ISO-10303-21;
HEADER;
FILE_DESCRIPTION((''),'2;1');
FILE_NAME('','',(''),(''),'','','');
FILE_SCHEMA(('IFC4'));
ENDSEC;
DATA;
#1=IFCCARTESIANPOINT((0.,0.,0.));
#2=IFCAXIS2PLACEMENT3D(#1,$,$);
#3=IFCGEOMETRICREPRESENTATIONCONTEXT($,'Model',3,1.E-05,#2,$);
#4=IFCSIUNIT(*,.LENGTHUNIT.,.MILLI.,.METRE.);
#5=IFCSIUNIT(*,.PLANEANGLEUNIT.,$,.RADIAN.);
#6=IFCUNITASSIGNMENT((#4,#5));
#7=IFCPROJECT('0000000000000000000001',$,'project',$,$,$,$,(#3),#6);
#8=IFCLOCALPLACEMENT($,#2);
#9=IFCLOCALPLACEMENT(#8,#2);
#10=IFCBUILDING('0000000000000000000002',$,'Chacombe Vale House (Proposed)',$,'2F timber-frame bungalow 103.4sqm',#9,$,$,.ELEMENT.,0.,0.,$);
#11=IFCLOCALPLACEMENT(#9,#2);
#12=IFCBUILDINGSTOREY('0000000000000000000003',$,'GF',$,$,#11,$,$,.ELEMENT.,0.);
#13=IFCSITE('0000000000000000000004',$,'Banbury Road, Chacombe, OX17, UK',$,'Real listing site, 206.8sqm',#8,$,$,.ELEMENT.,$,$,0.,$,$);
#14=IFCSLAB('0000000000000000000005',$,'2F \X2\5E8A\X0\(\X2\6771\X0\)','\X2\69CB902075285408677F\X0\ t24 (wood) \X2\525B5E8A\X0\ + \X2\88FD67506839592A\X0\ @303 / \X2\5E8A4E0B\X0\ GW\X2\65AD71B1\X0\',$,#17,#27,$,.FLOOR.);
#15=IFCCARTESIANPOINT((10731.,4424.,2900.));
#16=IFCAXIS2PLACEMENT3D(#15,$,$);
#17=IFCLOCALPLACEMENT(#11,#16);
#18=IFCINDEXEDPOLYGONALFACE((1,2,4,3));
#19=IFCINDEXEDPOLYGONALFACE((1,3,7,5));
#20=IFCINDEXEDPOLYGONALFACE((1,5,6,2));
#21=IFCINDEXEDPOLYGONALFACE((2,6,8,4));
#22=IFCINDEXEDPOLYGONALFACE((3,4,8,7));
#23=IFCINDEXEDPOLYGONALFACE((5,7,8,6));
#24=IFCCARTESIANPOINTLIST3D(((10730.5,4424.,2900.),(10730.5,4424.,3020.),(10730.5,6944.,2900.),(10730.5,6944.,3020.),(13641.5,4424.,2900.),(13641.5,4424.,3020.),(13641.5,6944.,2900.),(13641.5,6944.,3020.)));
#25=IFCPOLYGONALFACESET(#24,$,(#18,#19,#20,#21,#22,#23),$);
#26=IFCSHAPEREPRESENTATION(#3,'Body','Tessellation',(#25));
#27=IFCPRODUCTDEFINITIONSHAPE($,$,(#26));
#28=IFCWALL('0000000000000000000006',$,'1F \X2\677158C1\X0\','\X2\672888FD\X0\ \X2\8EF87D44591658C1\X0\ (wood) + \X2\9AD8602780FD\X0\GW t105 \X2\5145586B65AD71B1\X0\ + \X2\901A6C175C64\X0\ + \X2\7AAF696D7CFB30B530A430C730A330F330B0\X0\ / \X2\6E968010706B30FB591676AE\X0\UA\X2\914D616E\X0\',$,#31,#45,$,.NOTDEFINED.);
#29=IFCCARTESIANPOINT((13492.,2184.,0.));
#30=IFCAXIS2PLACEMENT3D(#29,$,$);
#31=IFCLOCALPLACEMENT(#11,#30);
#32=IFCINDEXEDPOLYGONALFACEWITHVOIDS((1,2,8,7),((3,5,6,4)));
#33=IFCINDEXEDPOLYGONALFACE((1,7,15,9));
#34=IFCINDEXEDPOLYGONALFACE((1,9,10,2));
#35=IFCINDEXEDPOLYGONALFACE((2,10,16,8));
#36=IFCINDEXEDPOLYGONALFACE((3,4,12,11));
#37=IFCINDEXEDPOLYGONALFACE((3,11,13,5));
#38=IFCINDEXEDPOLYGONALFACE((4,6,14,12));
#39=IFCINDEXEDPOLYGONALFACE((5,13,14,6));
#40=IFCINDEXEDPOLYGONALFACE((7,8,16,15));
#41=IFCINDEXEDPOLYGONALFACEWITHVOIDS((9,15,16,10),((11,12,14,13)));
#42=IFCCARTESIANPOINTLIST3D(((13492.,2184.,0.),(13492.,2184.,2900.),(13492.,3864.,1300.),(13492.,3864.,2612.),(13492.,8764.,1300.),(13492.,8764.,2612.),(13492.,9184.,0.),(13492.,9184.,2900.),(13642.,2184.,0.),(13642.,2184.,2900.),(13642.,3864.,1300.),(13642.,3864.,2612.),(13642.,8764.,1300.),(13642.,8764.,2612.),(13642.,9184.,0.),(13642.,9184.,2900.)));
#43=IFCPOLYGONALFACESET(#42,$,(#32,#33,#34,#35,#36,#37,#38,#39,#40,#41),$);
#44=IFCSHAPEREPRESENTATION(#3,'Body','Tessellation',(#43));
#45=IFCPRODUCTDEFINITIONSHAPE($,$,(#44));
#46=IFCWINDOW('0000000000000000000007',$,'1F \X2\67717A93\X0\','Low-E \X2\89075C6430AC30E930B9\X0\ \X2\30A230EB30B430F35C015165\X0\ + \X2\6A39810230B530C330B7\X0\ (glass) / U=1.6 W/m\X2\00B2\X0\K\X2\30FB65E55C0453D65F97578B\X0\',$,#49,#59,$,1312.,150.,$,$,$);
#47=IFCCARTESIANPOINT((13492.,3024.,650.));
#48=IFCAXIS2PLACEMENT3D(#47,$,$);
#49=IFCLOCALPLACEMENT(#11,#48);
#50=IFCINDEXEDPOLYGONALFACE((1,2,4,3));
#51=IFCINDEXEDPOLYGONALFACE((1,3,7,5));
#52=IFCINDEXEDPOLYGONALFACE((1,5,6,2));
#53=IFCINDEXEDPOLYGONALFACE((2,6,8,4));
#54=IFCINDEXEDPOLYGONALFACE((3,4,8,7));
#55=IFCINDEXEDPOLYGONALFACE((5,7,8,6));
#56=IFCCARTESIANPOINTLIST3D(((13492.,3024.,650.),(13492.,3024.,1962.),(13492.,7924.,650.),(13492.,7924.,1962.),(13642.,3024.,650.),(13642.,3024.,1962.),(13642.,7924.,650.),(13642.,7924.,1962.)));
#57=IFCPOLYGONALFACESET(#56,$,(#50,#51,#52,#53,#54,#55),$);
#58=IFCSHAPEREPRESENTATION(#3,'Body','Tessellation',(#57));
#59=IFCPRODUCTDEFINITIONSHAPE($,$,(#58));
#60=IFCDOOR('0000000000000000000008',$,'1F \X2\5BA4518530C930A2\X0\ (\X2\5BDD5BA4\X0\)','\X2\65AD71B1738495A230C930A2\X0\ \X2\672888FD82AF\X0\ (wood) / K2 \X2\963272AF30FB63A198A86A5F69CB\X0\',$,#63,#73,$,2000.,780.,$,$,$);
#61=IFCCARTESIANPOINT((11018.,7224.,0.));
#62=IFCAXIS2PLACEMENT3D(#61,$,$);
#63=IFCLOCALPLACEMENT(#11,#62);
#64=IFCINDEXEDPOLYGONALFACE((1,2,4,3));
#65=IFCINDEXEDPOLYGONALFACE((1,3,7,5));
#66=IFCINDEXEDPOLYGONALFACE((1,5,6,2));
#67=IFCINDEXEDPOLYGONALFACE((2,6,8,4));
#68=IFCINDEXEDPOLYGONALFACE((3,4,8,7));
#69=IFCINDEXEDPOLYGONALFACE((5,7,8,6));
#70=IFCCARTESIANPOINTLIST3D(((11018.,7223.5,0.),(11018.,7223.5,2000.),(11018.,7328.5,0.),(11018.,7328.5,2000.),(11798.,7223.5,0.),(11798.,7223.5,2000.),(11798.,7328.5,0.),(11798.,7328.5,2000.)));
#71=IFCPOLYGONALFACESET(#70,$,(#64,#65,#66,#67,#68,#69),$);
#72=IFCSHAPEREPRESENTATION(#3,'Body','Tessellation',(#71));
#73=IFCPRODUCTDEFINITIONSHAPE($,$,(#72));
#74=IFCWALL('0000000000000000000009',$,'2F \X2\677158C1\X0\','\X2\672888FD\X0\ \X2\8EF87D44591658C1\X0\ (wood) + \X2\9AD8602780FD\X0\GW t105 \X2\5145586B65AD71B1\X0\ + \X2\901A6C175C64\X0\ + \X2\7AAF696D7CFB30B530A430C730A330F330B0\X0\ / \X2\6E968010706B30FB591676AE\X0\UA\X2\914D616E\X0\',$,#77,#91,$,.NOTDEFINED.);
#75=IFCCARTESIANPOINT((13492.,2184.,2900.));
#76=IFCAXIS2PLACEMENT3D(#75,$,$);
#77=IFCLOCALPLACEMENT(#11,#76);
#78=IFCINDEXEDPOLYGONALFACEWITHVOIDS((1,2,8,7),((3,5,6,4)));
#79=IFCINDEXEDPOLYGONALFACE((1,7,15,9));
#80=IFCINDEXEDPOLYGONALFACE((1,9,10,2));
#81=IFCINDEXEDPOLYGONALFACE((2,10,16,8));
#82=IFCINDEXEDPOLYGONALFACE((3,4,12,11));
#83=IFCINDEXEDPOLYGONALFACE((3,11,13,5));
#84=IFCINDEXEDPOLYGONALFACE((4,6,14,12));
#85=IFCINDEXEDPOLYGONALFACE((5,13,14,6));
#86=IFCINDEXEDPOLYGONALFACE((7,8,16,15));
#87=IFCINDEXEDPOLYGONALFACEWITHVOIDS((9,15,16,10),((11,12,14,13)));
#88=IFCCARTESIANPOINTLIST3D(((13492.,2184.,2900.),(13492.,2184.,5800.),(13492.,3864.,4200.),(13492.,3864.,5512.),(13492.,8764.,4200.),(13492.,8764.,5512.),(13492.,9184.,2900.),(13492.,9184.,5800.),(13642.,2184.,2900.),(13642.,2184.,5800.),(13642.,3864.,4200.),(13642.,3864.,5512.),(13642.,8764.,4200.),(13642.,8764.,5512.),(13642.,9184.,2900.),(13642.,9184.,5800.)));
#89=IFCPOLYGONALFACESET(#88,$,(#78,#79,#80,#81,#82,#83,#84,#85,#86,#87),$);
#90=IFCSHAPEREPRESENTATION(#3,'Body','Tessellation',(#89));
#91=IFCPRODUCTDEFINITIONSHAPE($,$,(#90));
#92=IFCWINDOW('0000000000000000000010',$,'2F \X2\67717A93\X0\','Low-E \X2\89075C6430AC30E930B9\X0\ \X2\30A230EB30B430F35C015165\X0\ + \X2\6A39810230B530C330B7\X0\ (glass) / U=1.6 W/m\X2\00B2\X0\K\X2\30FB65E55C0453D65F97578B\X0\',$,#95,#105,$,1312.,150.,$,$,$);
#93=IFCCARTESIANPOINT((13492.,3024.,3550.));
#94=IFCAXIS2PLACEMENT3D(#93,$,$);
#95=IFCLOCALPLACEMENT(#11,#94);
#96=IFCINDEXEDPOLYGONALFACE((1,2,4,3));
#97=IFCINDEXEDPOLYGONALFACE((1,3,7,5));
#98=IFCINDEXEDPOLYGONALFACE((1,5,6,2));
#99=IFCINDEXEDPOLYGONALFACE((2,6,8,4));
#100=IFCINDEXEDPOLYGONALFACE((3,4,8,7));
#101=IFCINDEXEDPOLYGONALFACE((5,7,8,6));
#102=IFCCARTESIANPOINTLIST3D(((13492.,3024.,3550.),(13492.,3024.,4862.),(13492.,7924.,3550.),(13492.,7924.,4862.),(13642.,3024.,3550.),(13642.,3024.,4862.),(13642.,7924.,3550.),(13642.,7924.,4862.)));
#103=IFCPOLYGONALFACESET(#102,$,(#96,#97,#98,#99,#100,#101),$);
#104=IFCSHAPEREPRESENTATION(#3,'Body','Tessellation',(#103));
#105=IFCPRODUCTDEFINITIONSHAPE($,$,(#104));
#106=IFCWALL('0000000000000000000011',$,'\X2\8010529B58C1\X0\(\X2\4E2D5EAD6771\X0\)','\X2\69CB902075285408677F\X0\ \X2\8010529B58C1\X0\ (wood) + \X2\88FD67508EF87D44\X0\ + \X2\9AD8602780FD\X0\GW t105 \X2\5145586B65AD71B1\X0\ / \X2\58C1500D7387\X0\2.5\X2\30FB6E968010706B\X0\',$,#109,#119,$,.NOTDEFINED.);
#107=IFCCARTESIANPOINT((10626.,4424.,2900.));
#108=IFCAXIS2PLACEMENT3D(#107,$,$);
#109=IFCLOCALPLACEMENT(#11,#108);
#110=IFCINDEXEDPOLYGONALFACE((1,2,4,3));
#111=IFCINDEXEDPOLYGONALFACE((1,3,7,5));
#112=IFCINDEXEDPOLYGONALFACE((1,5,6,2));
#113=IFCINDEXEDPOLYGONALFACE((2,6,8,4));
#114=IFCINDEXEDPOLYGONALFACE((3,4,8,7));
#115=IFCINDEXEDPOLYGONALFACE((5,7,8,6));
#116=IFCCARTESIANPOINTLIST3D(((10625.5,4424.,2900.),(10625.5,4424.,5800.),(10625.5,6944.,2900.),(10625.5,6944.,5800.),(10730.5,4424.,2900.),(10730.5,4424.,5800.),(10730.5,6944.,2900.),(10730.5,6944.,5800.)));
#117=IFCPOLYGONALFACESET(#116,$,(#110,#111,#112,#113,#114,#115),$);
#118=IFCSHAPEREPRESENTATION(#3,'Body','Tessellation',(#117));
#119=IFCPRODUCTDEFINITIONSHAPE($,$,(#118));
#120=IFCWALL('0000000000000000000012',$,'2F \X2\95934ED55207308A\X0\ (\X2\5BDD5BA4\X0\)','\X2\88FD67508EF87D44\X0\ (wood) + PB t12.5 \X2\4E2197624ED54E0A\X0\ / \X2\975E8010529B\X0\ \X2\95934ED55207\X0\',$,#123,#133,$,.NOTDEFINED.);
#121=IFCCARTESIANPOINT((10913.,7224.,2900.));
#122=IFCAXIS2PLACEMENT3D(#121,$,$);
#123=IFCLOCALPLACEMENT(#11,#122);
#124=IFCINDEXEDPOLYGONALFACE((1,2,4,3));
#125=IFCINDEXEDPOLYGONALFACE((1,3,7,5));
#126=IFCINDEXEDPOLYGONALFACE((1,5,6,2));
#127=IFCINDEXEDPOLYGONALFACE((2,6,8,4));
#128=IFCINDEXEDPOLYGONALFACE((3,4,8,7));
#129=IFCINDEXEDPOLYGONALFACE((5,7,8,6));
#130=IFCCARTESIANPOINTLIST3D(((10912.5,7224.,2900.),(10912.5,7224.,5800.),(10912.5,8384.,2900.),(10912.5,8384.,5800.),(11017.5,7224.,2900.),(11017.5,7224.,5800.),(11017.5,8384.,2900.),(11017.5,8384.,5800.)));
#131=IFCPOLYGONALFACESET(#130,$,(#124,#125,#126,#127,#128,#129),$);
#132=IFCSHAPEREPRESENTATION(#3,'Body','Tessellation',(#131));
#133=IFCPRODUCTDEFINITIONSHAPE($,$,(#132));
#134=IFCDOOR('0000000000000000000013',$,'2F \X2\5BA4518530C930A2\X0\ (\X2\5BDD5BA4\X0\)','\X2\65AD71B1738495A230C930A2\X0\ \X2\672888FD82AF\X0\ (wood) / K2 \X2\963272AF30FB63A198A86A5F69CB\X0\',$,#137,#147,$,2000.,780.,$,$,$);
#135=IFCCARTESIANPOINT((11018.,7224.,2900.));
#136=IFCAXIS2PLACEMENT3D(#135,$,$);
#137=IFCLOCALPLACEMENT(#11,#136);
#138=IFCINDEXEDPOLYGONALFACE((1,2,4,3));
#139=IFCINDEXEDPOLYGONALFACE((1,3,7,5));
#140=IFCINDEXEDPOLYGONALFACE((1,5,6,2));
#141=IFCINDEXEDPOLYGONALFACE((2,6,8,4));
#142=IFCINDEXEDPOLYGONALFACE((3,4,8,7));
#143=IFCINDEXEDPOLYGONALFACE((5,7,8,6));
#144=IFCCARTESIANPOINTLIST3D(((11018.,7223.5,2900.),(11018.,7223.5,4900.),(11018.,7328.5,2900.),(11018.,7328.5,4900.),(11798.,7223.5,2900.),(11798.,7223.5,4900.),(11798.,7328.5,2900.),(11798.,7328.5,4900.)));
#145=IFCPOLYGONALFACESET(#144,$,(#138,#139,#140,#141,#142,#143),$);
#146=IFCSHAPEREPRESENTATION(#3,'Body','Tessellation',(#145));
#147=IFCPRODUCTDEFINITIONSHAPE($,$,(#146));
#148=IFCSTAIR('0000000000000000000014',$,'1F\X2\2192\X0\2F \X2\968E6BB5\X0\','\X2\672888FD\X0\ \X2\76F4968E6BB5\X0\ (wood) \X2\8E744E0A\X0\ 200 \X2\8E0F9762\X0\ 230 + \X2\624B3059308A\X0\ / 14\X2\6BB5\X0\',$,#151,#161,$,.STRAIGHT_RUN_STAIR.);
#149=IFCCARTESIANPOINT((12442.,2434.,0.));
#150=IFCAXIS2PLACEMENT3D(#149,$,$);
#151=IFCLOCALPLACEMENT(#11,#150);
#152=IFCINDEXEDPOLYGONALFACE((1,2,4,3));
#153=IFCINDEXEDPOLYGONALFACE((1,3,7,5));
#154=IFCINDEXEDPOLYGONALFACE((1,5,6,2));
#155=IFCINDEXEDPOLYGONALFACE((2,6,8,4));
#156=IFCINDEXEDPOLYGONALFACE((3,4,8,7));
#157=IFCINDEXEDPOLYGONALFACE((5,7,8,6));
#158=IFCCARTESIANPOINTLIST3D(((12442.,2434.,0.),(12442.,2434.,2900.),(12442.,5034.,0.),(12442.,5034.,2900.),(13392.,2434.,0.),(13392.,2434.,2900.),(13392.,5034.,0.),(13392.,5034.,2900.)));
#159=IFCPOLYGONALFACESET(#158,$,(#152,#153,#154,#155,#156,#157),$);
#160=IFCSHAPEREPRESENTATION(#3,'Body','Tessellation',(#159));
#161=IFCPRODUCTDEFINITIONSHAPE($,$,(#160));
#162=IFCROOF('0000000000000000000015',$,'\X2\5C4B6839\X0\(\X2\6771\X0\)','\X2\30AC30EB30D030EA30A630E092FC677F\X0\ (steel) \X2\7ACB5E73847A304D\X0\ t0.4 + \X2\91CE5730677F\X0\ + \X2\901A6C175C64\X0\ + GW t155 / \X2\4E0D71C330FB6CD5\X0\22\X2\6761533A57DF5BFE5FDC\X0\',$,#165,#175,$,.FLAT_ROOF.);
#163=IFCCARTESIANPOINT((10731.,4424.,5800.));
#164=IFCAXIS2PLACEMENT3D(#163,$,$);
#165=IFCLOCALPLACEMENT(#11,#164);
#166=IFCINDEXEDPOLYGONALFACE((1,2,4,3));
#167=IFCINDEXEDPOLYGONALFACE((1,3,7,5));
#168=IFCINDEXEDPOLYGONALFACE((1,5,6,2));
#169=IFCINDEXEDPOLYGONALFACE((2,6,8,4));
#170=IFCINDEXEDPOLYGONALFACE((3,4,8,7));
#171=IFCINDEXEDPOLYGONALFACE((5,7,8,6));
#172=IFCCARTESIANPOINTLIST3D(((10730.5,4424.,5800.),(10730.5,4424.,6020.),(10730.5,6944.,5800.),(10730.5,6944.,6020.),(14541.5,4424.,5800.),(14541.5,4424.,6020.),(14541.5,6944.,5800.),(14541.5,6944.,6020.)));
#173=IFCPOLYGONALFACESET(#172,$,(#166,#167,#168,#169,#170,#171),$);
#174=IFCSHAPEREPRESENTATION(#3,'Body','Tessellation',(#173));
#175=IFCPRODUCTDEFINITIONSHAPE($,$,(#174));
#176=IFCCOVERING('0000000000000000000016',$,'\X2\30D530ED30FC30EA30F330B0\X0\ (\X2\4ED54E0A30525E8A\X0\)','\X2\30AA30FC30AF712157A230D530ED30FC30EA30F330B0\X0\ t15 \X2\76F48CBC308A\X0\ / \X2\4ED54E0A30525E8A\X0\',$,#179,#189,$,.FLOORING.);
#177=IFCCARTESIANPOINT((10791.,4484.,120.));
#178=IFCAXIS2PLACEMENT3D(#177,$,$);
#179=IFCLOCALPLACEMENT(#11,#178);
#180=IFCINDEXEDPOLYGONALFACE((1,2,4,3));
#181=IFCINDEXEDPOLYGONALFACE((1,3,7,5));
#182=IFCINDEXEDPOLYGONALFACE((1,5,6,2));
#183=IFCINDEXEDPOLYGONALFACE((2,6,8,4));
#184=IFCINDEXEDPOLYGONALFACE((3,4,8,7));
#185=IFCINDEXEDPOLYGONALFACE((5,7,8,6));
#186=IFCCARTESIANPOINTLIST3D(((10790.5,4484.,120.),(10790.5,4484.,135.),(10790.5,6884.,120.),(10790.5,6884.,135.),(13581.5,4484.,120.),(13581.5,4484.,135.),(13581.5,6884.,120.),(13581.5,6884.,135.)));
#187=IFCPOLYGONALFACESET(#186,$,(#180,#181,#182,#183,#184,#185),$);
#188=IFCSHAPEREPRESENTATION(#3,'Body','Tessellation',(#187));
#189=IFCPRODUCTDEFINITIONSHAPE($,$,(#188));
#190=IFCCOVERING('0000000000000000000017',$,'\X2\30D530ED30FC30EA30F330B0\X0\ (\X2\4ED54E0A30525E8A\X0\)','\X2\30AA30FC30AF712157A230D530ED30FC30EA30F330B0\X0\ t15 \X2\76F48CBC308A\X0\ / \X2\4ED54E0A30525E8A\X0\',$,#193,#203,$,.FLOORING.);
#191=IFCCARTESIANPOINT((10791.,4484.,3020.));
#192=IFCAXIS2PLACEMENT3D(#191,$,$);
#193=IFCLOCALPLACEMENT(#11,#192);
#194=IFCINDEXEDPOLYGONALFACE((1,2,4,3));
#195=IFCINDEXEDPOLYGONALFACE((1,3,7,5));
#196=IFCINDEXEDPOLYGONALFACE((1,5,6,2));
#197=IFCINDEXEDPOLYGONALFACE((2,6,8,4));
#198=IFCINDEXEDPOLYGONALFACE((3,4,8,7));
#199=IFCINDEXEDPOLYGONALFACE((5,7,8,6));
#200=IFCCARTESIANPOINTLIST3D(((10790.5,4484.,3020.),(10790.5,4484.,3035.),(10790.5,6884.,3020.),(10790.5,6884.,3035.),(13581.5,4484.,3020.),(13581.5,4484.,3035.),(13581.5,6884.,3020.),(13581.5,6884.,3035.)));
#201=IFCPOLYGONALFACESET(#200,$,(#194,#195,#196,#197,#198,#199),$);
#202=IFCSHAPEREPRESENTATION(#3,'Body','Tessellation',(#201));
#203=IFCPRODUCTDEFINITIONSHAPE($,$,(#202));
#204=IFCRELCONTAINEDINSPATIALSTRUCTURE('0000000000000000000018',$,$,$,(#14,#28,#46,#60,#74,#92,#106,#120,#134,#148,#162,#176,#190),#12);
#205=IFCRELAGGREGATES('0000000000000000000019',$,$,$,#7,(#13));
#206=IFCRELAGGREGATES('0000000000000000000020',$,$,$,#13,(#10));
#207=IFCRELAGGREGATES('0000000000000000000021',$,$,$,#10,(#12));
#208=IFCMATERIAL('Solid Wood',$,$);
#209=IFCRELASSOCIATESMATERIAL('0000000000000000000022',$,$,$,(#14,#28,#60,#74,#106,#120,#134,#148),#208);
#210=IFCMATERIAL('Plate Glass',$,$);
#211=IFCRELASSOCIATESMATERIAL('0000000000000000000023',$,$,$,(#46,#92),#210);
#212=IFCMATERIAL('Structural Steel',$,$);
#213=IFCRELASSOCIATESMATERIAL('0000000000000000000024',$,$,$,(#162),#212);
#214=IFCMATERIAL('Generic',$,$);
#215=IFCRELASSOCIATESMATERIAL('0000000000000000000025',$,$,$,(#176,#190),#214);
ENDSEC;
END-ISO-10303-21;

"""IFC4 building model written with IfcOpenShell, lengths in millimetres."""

from ifc_helpers import new_model, si_unit, frame, frame_2d, origin, place, context, project, spatial, rectangle, extrude, material, element, fill, save


model = new_model("IFC4")

# Units and contexts
model_context = context("Model", 3, precision=1e-05, world=origin())
ifc_project = project(units=[si_unit("LENGTHUNIT", "METRE", prefix="MILLI"), si_unit("PLANEANGLEUNIT", "RADIAN")], contexts=[model_context])

# Site, building, storey
site_placement = place(None, origin())
site = spatial("IfcSite", under=ifc_project, at=site_placement, Name="Banbury Road, Chacombe, OX17, UK", ObjectType="Real listing site, 206.8sqm", CompositionType="ELEMENT", RefElevation=0.0)
building_placement = place(site_placement, origin())
building = spatial("IfcBuilding", under=site, at=building_placement, Name="Chacombe Vale House (Proposed)", ObjectType="2F timber-frame bungalow 103.4sqm", CompositionType="ELEMENT", ElevationOfRefHeight=0.0, ElevationOfTerrain=0.0)
storey_placement = place(building_placement, origin())
storey = spatial("IfcBuildingStorey", under=building, at=storey_placement, Name="GF", CompositionType="ELEMENT", Elevation=0.0)

# Slab
ifc_material_1 = material(Name="Solid Wood")
slab_1_placement = place(storey_placement, frame((10731.0, 4424.0, 2900.0)))
element("IfcSlab", 1, at=slab_1_placement, inside=storey, material=ifc_material_1, Name="2F 床(東)", Description="構造用合板 t24 (wood) 剛床 + 製材根太 @303 / 床下 GW断熱", PredefinedType="FLOOR", context=model_context, shape_type="SweptSolid", body=[
    extrude(rectangle(XDim=2911.0, YDim=2520.0, at=frame_2d((1455.0, 1260.0))), frame((10731.0, 4424.0, 2900.0)), (0.0, 0.0, 1.0), 120.0),
])

# Wall, opening, window
wall_1_placement = place(storey_placement, frame((13492.0, 2184.0, 0.0)))
wall_1 = element("IfcWall", 2, at=wall_1_placement, inside=storey, material=ifc_material_1, Name="1F 東壁", Description="木製 軸組外壁 (wood) + 高性能GW t105 充填断熱 + 通気層 + 窯業系サイディング / 準耐火・外皮UA配慮", PredefinedType="NOTDEFINED", context=model_context, shape_type="SweptSolid", body=[
    extrude(rectangle(XDim=150.0, YDim=7000.0, at=frame_2d((75.0, 3500.0))), frame((13492.0, 2184.0, 0.0)), (0.0, 0.0, 1.0), 2900.0),
])
opening_1_placement = place(storey_placement, frame((13492.0, 3024.0, 650.0)))
opening_1 = element("IfcOpeningElement", 3, at=opening_1_placement, cuts=wall_1, PredefinedType="NOTDEFINED", context=model_context, shape_type="SweptSolid", body=[
    extrude(rectangle(XDim=150.0, YDim=4900.0, at=frame_2d((75.0, 2450.0))), frame((13492.0, 3024.0, 650.0)), (0.0, 0.0, 1.0), 1312.0),
])
ifc_material_2 = material(Name="Plate Glass")
window_1_placement = place(storey_placement, frame((13492.0, 3024.0, 650.0)))
window_1 = element("IfcWindow", 4, at=window_1_placement, inside=storey, material=ifc_material_2, Name="1F 東窓", Description="Low-E 複層ガラス アルゴン封入 + 樹脂サッシ (glass) / U=1.6 W/m²K・日射取得型", OverallHeight=1312.0, OverallWidth=150.0, context=model_context, shape_type="SweptSolid", body=[
    extrude(rectangle(XDim=150.0, YDim=4900.0, at=frame_2d((75.0, 2450.0))), frame((13492.0, 3024.0, 650.0)), (0.0, 0.0, 1.0), 1312.0),
])
fill(opening_1, window_1)

# Door
door_1_placement = place(storey_placement, frame((11018.0, 7224.0, 0.0)))
element("IfcDoor", 5, at=door_1_placement, inside=storey, material=ifc_material_1, Name="1F 室内ドア (寝室)", Description="断熱玄関ドア 木製芯 (wood) / K2 防犯・採風機構", OverallHeight=2000.0, OverallWidth=780.0, context=model_context, shape_type="SweptSolid", body=[
    extrude(rectangle(XDim=780.0, YDim=105.0, at=frame_2d((390.0, 52.0))), frame((11018.0, 7224.0, 0.0)), (0.0, 0.0, 1.0), 2000.0),
])

# Wall, opening, window
wall_2_placement = place(storey_placement, frame((13492.0, 2184.0, 2900.0)))
wall_2 = element("IfcWall", 6, at=wall_2_placement, inside=storey, material=ifc_material_1, Name="2F 東壁", Description="木製 軸組外壁 (wood) + 高性能GW t105 充填断熱 + 通気層 + 窯業系サイディング / 準耐火・外皮UA配慮", PredefinedType="NOTDEFINED", context=model_context, shape_type="SweptSolid", body=[
    extrude(rectangle(XDim=150.0, YDim=7000.0, at=frame_2d((75.0, 3500.0))), frame((13492.0, 2184.0, 2900.0)), (0.0, 0.0, 1.0), 2900.0),
])
opening_2_placement = place(storey_placement, frame((13492.0, 3024.0, 3550.0)))
opening_2 = element("IfcOpeningElement", 7, at=opening_2_placement, cuts=wall_2, PredefinedType="NOTDEFINED", context=model_context, shape_type="SweptSolid", body=[
    extrude(rectangle(XDim=150.0, YDim=4900.0, at=frame_2d((75.0, 2450.0))), frame((13492.0, 3024.0, 3550.0)), (0.0, 0.0, 1.0), 1312.0),
])
window_2_placement = place(storey_placement, frame((13492.0, 3024.0, 3550.0)))
window_2 = element("IfcWindow", 8, at=window_2_placement, inside=storey, material=ifc_material_2, Name="2F 東窓", Description="Low-E 複層ガラス アルゴン封入 + 樹脂サッシ (glass) / U=1.6 W/m²K・日射取得型", OverallHeight=1312.0, OverallWidth=150.0, context=model_context, shape_type="SweptSolid", body=[
    extrude(rectangle(XDim=150.0, YDim=4900.0, at=frame_2d((75.0, 2450.0))), frame((13492.0, 3024.0, 3550.0)), (0.0, 0.0, 1.0), 1312.0),
])
fill(opening_2, window_2)

# Walls
wall_3_placement = place(storey_placement, frame((10626.0, 4424.0, 2900.0)))
element("IfcWall", 9, at=wall_3_placement, inside=storey, material=ifc_material_1, Name="耐力壁(中庭東)", Description="構造用合板 耐力壁 (wood) + 製材軸組 + 高性能GW t105 充填断熱 / 壁倍率2.5・準耐火", PredefinedType="NOTDEFINED", context=model_context, shape_type="SweptSolid", body=[
    extrude(rectangle(XDim=105.0, YDim=2520.0, at=frame_2d((52.0, 1260.0))), frame((10626.0, 4424.0, 2900.0)), (0.0, 0.0, 1.0), 2900.0),
])
wall_4_placement = place(storey_placement, frame((10913.0, 7224.0, 2900.0)))
element("IfcWall", 10, at=wall_4_placement, inside=storey, material=ifc_material_1, Name="2F 間仕切り (寝室)", Description="製材軸組 (wood) + PB t12.5 両面仕上 / 非耐力 間仕切", PredefinedType="NOTDEFINED", context=model_context, shape_type="SweptSolid", body=[
    extrude(rectangle(XDim=105.0, YDim=1160.0, at=frame_2d((52.0, 580.0))), frame((10913.0, 7224.0, 2900.0)), (0.0, 0.0, 1.0), 2900.0),
])

# Door
door_2_placement = place(storey_placement, frame((11018.0, 7224.0, 2900.0)))
element("IfcDoor", 11, at=door_2_placement, inside=storey, material=ifc_material_1, Name="2F 室内ドア (寝室)", Description="断熱玄関ドア 木製芯 (wood) / K2 防犯・採風機構", OverallHeight=2000.0, OverallWidth=780.0, context=model_context, shape_type="SweptSolid", body=[
    extrude(rectangle(XDim=780.0, YDim=105.0, at=frame_2d((390.0, 52.0))), frame((11018.0, 7224.0, 2900.0)), (0.0, 0.0, 1.0), 2000.0),
])

# Stair
stair_placement = place(storey_placement, frame((12442.0, 2434.0, 0.0)))
element("IfcStair", 12, at=stair_placement, inside=storey, material=ifc_material_1, Name="1F→2F 階段", Description="木製 直階段 (wood) 蹴上 200 踏面 230 + 手すり / 14段", PredefinedType="STRAIGHT_RUN_STAIR", context=model_context, shape_type="SweptSolid", body=[
    extrude(rectangle(XDim=950.0, YDim=2600.0, at=frame_2d((475.0, 1300.0))), frame((12442.0, 2434.0, 0.0)), (0.0, 0.0, 1.0), 2900.0),
])

# Roof
ifc_material_3 = material(Name="Structural Steel")
for number, where, name in (
    (13, (10731.0, 4424.0, 5800.0), "屋根(東)"),
):
    element("IfcRoof", number, at=place(storey_placement, frame(where)), inside=storey, material=ifc_material_3, Name=name, Description="ガルバリウム鋼板 (steel) 立平葺き t0.4 + 野地板 + 通気層 + GW t155 / 不燃・法22条区域対応", PredefinedType="FLAT_ROOF", context=model_context, shape_type="SweptSolid", body=[
        extrude(rectangle(XDim=3811.0, YDim=2520.0, at=frame_2d((1905.0, 1260.0))), frame((10731.0, 4424.0, 5800.0)), (0.0, 0.0, 1.0), 220.0),
    ])

# Coverings
ifc_material_4 = material(Name="Generic")
covering_1_placement = place(storey_placement, frame((10791.0, 4484.0, 120.0)))
element("IfcCovering", 14, at=covering_1_placement, inside=storey, material=ifc_material_4, Name="フローリング (仕上げ床)", Description="オーク無垢フローリング t15 直貼り / 仕上げ床", PredefinedType="FLOORING", context=model_context, shape_type="SweptSolid", body=[
    extrude(rectangle(XDim=2791.0, YDim=2400.0, at=frame_2d((1395.0, 1200.0))), frame((10791.0, 4484.0, 120.0)), (0.0, 0.0, 1.0), 15.0),
])
covering_2_placement = place(storey_placement, frame((10791.0, 4484.0, 3020.0)))
element("IfcCovering", 15, at=covering_2_placement, inside=storey, material=ifc_material_4, Name="フローリング (仕上げ床)", Description="オーク無垢フローリング t15 直貼り / 仕上げ床", PredefinedType="FLOORING", context=model_context, shape_type="SweptSolid", body=[
    extrude(rectangle(XDim=2791.0, YDim=2400.0, at=frame_2d((1395.0, 1200.0))), frame((10791.0, 4484.0, 3020.0)), (0.0, 0.0, 1.0), 15.0),
])

save(model, "model.ifc")
